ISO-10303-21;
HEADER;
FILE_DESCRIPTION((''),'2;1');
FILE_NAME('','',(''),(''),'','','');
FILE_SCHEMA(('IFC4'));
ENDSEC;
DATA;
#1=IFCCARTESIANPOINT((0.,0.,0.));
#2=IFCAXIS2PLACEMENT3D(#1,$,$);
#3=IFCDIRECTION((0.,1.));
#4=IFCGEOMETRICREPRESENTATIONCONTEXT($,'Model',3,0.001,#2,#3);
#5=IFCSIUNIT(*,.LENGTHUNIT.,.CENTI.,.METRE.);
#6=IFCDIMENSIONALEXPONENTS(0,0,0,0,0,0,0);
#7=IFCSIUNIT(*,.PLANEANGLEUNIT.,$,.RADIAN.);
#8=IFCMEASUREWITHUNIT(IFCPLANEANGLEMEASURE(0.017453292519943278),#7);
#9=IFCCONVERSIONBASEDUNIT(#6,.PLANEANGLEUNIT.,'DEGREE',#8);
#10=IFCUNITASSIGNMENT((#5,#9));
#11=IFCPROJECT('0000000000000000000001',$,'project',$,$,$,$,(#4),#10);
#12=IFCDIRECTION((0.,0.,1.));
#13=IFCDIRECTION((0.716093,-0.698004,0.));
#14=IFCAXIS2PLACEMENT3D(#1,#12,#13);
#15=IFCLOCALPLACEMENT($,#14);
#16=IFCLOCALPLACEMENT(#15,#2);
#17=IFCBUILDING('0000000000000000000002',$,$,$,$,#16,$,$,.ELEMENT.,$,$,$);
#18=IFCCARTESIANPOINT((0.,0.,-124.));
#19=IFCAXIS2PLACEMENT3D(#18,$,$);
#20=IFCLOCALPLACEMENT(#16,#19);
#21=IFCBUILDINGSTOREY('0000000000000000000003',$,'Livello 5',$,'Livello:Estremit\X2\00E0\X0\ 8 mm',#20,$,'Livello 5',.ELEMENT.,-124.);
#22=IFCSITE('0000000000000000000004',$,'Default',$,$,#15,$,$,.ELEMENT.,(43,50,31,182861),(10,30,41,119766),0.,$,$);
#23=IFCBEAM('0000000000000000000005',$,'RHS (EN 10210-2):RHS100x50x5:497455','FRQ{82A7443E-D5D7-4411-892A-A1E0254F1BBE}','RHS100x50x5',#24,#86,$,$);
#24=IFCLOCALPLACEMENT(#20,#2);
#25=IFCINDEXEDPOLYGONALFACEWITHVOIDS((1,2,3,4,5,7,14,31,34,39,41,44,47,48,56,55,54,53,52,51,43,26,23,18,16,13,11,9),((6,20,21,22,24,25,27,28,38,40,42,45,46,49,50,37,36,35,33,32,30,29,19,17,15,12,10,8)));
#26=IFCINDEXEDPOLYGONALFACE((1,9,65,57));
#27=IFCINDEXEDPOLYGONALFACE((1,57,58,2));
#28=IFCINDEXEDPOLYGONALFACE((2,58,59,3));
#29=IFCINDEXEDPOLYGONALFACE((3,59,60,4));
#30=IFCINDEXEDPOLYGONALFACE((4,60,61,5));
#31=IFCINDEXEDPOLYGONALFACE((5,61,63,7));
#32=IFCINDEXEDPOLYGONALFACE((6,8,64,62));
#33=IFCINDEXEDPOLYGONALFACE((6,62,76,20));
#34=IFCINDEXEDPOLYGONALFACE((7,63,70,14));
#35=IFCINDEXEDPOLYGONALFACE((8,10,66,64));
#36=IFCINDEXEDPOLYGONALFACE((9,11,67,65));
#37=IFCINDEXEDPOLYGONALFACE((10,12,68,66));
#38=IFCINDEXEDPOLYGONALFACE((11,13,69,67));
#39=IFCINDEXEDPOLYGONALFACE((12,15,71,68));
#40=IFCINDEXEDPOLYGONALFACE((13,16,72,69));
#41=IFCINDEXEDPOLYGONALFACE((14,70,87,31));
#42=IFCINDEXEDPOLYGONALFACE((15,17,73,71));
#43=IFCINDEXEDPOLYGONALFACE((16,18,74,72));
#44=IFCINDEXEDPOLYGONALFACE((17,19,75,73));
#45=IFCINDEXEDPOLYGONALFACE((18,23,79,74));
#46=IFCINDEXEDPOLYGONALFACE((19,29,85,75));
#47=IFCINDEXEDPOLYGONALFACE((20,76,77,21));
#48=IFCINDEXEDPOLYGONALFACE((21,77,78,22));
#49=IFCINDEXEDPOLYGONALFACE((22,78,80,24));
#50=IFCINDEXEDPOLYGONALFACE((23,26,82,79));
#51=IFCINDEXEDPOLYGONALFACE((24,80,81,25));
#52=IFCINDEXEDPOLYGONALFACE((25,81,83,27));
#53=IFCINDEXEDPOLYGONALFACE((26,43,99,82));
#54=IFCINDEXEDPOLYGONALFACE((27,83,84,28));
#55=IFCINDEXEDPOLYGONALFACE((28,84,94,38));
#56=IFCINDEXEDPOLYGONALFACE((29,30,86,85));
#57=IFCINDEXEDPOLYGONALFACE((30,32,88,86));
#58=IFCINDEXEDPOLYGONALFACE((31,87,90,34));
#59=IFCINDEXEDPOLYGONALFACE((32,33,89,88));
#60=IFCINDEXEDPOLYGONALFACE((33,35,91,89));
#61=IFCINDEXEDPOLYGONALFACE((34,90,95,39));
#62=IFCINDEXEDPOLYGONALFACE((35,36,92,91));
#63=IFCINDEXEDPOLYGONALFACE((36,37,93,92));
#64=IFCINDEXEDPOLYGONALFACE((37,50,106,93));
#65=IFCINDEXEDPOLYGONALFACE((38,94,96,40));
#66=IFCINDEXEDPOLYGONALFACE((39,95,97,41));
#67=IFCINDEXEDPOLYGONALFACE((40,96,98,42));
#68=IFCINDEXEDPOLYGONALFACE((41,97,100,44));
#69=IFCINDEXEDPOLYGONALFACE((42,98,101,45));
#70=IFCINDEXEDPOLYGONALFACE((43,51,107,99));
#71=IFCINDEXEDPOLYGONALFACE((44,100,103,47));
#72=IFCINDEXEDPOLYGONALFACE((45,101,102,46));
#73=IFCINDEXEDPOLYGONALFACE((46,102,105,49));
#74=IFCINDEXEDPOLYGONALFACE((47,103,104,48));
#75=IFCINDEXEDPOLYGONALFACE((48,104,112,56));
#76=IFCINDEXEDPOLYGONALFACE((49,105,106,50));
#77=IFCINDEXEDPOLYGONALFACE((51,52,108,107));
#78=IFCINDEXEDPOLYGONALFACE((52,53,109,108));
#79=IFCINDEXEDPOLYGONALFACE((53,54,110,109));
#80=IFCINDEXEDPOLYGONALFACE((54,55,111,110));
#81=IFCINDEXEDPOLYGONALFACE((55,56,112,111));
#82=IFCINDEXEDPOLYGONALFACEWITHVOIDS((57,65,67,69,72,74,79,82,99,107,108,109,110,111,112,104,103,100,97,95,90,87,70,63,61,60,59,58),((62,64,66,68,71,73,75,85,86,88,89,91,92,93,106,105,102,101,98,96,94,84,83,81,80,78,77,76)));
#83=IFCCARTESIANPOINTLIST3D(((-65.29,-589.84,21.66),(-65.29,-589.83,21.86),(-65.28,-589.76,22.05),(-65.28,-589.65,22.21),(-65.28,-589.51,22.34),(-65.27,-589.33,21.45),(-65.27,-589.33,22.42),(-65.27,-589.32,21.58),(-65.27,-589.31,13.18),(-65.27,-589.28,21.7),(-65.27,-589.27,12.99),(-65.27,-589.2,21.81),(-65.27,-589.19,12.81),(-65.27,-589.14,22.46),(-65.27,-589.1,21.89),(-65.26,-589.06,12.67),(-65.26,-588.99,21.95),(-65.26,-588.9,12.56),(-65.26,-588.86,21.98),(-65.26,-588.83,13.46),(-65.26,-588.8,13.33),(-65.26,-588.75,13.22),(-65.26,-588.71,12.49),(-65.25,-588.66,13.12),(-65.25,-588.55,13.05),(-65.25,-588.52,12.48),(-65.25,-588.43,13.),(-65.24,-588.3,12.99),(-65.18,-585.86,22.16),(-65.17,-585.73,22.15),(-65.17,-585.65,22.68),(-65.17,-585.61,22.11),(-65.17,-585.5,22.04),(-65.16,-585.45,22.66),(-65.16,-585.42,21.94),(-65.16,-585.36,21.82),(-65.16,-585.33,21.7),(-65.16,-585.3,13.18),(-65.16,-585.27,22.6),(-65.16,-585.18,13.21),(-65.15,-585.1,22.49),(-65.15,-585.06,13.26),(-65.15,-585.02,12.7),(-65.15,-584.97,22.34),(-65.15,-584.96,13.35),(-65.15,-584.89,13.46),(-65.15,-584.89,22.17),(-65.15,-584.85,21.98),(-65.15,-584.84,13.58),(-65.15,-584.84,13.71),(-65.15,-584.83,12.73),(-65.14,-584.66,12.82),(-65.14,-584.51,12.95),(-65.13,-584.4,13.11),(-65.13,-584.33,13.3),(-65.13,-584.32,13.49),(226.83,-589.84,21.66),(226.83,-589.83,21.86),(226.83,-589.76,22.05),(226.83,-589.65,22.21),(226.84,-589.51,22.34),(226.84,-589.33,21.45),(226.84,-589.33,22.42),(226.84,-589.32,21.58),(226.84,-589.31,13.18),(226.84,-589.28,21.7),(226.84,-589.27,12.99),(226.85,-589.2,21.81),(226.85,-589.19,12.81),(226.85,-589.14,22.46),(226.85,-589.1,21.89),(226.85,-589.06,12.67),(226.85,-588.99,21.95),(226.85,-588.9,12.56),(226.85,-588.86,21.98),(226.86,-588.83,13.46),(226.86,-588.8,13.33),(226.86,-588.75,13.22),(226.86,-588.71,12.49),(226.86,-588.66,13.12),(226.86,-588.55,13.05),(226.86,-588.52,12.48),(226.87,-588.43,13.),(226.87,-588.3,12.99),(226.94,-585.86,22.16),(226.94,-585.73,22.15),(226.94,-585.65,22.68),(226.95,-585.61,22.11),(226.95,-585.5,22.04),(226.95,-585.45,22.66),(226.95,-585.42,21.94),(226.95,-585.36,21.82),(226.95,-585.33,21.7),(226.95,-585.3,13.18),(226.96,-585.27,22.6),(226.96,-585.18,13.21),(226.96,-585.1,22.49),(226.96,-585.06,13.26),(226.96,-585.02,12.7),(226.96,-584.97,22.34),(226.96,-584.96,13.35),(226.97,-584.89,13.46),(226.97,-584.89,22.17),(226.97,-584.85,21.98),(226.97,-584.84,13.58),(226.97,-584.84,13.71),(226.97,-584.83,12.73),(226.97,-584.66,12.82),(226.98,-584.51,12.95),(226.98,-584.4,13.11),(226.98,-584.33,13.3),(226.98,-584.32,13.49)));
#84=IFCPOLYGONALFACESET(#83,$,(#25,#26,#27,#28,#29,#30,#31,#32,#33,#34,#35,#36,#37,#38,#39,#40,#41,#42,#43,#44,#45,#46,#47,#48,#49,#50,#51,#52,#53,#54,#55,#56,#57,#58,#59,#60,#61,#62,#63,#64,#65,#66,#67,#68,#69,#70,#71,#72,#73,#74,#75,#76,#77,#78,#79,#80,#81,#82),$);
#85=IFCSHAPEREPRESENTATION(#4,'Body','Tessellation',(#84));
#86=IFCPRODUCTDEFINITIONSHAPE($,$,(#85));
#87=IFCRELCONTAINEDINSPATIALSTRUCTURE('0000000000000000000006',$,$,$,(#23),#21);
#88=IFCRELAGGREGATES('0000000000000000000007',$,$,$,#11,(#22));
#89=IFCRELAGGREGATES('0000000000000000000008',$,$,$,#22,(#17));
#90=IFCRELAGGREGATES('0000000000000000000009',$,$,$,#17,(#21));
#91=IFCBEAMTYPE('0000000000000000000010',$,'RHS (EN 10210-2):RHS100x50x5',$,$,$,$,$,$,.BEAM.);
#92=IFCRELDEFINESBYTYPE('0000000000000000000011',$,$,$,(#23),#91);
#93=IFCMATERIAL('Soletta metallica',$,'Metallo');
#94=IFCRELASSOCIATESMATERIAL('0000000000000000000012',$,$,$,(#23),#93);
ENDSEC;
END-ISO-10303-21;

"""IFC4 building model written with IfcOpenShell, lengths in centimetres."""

from ifc_helpers import new_model, entity, si_unit, converted_unit, direction, frame, origin, origin_2d, place, context, project, spatial, hollow_rectangle, extrude, clip, halfspace, material, type_object, element, save


model = new_model("IFC4")

# Units and contexts
model_context = context("Model", 3, precision=0.001, world=origin(), true_north=direction((0.0, 1.0)))
ifc_project = project(units=[si_unit("LENGTHUNIT", "METRE", prefix="CENTI"), converted_unit("PLANEANGLEUNIT", "DEGREE", entity("IfcPlaneAngleMeasure", 0.017453292519943278), si_unit("PLANEANGLEUNIT", "RADIAN"), dimensions=[0, 0, 0, 0, 0, 0, 0])], contexts=[model_context])

# Site, building, storey
site_placement = place(None, frame((0.0, 0.0, 0.0), z_axis=(0.0, 0.0, 1.0), x_axis=(0.716093, -0.698004, 0.0)))
site = spatial("IfcSite", under=ifc_project, at=site_placement, Name="Default", CompositionType="ELEMENT", RefLatitude=(43, 50, 31, 182861), RefLongitude=(10, 30, 41, 119766), RefElevation=0.0)
building_placement = place(site_placement, origin())
building = spatial("IfcBuilding", under=site, at=building_placement, CompositionType="ELEMENT")
storey_placement = place(building_placement, frame((0.0, 0.0, -124.0)))
storey = spatial("IfcBuildingStorey", under=building, at=storey_placement, Name="Livello 5", ObjectType="Livello:Estremità 8 mm", LongName="Livello 5", CompositionType="ELEMENT", Elevation=-124.0)

# Shared definitions
ifc_material = material(Name="Soletta metallica", Category="Metallo")
beam_type_1 = type_object("IfcBeamType", Name="RHS (EN 10210-2):RHS100x50x5", PredefinedType="BEAM")

# Beam
beam_1_placement = place(storey_placement, frame((246.51, -587.08, 17.58), z_axis=(1.0, 0.0, 0.0), x_axis=(0.0, 0.998059, 0.062268)))
element("IfcBeam", 1, at=beam_1_placement, inside=storey, type_object=beam_type_1, material=ifc_material, Name="RHS (EN 10210-2):RHS100x50x5:497455", Description="FRQ{82A7443E-D5D7-4411-892A-A1E0254F1BBE}", ObjectType="RHS100x50x5", context=model_context, shape_type="Clipping", body=[
    clip(clip(extrude(hollow_rectangle(XDim=5.0, YDim=10.0, WallThickness=0.5, InnerFilletRadius=0.5, OuterFilletRadius=0.75, at=origin_2d()), origin(), (0.0, 0.0, -1.0), 331.31), halfspace(frame((585.78, 70.08, -3.36), z_axis=(0.027926, -0.001742, -0.999608), x_axis=(-0.997669, 0.062244, -0.02798)), True)), halfspace(frame((593.93, 69.57, -295.25), z_axis=(-0.027926, 0.001742, 0.999608), x_axis=(0.997669, -0.062244, 0.02798)), True)),
])

save(model, "model.ifc")
